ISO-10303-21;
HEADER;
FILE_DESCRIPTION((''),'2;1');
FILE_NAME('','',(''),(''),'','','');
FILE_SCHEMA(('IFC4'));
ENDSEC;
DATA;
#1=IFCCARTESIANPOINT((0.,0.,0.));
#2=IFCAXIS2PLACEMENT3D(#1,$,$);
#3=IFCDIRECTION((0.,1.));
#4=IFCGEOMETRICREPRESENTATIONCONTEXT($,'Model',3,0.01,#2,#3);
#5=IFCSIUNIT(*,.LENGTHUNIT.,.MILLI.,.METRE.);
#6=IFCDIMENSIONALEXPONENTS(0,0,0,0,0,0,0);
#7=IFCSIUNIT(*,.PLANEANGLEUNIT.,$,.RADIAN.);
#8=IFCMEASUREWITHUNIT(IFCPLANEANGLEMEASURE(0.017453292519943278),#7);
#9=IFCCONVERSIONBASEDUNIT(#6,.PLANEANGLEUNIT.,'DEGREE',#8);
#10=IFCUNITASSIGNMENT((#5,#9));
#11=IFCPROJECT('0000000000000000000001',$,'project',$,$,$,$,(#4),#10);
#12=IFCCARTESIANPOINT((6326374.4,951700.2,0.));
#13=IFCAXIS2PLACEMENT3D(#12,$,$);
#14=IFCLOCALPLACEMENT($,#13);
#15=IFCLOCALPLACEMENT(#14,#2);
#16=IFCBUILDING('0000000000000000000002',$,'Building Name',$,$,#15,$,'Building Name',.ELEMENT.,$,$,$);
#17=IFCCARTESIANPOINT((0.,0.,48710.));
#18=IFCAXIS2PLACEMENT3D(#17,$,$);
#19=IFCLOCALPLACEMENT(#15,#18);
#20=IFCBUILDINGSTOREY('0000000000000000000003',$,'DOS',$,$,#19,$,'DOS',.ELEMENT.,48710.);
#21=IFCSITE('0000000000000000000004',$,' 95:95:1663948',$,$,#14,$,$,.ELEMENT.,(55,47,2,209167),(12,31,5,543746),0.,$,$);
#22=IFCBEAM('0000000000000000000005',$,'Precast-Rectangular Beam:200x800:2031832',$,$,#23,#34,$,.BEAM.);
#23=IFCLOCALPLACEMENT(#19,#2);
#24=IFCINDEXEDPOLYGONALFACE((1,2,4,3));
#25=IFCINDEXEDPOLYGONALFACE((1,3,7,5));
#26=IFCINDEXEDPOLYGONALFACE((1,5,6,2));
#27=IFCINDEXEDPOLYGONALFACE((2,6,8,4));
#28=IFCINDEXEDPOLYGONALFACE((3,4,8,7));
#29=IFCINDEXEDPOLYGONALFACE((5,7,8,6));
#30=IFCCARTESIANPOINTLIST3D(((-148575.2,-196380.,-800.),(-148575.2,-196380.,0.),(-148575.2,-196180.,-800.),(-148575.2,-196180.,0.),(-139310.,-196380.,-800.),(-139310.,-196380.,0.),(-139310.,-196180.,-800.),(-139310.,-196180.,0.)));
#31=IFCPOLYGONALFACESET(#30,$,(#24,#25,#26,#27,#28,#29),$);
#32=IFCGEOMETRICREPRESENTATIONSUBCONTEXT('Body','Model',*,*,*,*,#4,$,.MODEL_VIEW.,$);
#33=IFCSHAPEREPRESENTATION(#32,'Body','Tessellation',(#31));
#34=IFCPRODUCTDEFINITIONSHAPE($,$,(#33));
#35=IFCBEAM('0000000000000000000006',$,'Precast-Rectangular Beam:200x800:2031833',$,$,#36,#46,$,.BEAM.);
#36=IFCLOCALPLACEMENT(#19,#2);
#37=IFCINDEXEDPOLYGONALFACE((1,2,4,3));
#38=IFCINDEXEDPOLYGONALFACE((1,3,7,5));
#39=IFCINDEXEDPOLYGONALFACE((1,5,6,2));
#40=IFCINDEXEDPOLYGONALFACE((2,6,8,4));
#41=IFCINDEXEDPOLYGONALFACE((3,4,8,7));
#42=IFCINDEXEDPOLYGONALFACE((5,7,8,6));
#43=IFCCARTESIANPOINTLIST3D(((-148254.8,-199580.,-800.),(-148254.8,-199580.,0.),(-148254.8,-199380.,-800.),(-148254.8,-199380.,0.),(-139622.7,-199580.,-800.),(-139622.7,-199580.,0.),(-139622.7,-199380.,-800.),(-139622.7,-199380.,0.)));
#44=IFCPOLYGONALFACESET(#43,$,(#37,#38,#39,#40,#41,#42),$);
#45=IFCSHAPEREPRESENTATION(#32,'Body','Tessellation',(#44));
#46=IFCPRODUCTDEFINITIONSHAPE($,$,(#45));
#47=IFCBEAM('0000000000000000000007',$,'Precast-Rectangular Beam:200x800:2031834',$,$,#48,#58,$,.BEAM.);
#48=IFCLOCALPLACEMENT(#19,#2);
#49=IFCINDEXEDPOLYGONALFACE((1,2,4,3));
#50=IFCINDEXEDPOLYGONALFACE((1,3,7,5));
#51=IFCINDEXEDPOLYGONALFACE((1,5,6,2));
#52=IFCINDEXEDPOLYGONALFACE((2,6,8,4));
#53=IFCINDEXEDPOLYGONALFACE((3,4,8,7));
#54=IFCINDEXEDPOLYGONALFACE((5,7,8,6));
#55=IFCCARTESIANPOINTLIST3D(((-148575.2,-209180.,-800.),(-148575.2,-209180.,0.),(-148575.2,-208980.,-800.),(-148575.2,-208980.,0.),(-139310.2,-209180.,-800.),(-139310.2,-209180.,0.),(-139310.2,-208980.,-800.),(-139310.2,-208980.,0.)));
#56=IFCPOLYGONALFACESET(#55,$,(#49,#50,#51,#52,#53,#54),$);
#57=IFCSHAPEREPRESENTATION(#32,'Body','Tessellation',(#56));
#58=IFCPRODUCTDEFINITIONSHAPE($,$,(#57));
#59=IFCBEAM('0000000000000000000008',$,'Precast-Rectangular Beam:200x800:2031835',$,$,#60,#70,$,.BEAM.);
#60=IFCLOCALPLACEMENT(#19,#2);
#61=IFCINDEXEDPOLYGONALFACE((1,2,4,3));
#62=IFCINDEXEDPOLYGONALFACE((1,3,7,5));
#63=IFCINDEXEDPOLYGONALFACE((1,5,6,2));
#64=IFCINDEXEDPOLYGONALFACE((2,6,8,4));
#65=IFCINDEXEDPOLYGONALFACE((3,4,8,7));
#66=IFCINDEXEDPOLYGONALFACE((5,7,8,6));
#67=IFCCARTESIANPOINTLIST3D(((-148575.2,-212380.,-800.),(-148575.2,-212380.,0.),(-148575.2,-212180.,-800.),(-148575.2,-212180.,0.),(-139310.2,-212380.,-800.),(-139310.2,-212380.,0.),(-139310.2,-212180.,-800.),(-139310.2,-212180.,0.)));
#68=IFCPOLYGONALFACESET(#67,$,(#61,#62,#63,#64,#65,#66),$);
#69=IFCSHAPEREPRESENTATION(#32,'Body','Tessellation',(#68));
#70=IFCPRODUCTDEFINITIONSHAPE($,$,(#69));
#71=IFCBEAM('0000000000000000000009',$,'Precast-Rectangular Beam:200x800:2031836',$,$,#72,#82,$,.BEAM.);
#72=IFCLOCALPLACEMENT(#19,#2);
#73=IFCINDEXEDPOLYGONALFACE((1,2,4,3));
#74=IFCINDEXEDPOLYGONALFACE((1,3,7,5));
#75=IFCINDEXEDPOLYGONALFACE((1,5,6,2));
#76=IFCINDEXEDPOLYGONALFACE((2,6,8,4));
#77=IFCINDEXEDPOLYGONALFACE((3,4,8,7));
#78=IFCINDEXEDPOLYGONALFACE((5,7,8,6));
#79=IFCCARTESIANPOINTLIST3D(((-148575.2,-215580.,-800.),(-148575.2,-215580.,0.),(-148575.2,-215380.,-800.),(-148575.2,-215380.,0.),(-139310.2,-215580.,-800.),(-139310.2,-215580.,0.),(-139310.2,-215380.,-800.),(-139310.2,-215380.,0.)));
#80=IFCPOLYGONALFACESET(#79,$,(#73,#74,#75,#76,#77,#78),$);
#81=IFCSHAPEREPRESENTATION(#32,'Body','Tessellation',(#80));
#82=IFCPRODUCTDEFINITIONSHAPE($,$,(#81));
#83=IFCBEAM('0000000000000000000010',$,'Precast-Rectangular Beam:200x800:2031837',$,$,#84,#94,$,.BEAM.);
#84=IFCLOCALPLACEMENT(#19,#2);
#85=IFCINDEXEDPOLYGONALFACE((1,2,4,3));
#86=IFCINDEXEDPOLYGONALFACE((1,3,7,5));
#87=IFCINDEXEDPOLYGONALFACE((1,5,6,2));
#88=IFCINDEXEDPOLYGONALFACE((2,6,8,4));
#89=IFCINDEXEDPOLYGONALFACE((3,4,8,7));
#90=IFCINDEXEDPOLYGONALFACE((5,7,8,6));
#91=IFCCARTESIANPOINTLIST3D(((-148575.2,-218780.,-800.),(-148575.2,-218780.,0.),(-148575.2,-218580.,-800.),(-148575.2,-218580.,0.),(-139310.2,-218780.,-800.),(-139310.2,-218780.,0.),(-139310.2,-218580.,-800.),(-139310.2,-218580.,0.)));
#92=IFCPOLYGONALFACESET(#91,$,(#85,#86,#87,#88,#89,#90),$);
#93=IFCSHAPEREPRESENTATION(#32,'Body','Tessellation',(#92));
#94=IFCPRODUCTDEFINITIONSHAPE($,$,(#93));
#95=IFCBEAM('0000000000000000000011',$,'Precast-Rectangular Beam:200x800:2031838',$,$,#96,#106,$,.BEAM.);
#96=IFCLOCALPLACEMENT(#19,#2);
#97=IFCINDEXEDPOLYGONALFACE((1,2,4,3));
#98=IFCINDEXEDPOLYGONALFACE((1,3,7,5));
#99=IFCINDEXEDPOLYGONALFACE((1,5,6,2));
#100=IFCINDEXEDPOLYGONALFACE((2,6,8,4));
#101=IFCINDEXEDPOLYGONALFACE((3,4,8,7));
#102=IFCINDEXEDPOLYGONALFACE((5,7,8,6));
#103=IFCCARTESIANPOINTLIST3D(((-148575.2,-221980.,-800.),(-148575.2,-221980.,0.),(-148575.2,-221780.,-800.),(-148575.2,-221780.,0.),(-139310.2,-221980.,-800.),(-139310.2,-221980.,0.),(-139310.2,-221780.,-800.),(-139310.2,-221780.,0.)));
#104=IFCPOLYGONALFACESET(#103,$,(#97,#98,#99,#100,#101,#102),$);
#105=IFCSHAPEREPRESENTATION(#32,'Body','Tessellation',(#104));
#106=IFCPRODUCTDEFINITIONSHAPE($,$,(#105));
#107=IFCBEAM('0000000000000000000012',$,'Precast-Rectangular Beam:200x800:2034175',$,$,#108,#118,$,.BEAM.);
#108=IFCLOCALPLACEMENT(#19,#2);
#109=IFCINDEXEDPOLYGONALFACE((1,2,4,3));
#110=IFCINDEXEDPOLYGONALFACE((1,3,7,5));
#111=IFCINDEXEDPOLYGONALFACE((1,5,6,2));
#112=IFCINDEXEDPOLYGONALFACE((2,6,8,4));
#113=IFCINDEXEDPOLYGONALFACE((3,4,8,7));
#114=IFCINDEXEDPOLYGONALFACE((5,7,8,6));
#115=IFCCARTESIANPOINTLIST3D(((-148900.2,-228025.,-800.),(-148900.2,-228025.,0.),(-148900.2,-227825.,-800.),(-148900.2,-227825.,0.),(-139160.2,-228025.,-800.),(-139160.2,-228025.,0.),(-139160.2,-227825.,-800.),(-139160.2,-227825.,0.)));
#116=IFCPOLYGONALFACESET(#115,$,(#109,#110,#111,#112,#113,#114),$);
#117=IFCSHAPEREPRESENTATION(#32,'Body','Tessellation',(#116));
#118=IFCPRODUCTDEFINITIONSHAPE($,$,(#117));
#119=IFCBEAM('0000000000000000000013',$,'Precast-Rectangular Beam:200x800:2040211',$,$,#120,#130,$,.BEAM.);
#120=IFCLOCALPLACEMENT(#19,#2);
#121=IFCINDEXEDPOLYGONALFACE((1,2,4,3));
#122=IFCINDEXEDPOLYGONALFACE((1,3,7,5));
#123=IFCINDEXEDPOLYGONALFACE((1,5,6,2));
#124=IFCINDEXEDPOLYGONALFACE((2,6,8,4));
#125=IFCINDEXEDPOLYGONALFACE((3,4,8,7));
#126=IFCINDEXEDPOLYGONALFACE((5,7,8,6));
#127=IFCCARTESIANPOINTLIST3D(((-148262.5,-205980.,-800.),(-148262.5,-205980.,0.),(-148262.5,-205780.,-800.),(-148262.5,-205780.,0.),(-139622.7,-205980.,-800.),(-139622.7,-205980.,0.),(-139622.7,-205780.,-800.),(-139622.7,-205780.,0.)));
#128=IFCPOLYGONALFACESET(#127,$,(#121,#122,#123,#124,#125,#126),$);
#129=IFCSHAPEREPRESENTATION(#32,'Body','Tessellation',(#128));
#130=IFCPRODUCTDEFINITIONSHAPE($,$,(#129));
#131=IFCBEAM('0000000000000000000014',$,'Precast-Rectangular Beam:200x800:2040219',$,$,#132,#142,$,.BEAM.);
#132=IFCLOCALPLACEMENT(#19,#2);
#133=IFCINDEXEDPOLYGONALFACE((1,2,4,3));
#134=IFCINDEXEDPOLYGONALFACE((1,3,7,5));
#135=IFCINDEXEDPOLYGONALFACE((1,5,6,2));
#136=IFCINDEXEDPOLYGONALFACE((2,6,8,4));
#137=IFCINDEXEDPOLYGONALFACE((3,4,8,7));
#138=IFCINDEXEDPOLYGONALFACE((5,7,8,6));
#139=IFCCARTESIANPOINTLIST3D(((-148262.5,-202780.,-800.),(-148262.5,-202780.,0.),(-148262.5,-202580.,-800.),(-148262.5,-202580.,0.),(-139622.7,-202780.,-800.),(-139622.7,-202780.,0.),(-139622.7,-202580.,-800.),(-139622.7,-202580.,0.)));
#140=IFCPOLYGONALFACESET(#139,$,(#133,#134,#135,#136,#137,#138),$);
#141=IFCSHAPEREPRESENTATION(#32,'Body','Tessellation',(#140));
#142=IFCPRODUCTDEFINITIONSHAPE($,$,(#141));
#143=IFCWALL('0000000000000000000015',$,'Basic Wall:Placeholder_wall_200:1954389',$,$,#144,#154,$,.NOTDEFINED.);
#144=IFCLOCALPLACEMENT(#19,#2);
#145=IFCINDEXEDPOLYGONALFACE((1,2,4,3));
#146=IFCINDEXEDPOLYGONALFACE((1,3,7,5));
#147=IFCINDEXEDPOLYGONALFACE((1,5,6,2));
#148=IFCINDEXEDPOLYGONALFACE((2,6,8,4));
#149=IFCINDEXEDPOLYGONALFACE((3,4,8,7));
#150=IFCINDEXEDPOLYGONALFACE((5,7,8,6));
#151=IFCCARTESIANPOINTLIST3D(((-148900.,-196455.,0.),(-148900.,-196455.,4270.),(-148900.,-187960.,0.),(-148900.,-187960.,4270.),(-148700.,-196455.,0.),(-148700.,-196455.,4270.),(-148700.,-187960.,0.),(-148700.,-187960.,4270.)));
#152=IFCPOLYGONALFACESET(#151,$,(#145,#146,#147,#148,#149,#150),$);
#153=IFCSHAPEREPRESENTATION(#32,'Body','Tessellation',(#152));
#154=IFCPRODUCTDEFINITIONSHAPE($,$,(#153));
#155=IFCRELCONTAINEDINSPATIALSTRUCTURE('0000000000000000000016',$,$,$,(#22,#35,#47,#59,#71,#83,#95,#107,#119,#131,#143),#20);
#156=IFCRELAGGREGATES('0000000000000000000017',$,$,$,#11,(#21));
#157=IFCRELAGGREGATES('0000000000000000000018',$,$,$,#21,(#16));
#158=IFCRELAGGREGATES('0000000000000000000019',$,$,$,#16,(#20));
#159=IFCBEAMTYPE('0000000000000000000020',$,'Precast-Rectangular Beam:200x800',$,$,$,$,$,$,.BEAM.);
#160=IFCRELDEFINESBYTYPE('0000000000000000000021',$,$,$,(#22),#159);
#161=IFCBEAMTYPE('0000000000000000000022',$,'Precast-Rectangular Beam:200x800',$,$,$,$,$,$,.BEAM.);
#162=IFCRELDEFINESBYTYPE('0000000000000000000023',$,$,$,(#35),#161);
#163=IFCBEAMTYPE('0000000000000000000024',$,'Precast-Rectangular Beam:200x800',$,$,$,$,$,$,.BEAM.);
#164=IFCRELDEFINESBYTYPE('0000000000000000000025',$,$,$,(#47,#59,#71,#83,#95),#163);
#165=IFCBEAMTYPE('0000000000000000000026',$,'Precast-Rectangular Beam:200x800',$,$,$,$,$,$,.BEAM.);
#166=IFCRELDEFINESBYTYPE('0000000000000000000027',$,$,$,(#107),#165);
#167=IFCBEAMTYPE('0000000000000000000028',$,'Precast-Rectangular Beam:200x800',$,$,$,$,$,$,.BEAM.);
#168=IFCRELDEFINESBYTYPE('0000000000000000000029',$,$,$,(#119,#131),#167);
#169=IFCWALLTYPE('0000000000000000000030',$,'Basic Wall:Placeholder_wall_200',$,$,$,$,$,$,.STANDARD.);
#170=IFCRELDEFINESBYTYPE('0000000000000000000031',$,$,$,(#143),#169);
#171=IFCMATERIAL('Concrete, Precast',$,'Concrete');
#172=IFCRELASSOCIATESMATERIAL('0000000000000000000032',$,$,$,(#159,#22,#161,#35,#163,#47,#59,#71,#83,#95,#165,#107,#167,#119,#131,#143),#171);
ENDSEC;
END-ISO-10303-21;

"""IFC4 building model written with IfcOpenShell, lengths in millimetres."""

from ifc_helpers import new_model, entity, si_unit, converted_unit, direction, frame, origin, place, context, subcontext, project, spatial, indexed_curve, outline, extrude, source, transform, mapped, material, type_object, type_shapes, element, save


model = new_model("IFC4")

# Units and contexts
model_context = context("Model", 3, precision=0.01, world=origin(), true_north=direction((0.0, 1.0)))
body_context = subcontext(model_context, "Body", "Model", "MODEL_VIEW")
ifc_project = project(units=[si_unit("LENGTHUNIT", "METRE", prefix="MILLI"), converted_unit("PLANEANGLEUNIT", "DEGREE", entity("IfcPlaneAngleMeasure", 0.017453292519943278), si_unit("PLANEANGLEUNIT", "RADIAN"), dimensions=[0, 0, 0, 0, 0, 0, 0])], contexts=[model_context])

# Site, building, storey
site_placement = place(None, frame((6326374.4, 951700.2, 0.0)))
site = spatial("IfcSite", under=ifc_project, at=site_placement, Name=" 95:95:1663948", CompositionType="ELEMENT", RefLatitude=(55, 47, 2, 209167), RefLongitude=(12, 31, 5, 543746), RefElevation=0.0)
building_placement = place(site_placement, origin())
building = spatial("IfcBuilding", under=site, at=building_placement, Name="Building Name", LongName="Building Name", CompositionType="ELEMENT")
storey_placement = place(building_placement, frame((0.0, 0.0, 48710.0)))
storey = spatial("IfcBuildingStorey", under=building, at=storey_placement, Name="DOS", LongName="DOS", CompositionType="ELEMENT", Elevation=48710.0)

# Beams
ifc_material_1 = material(Name="Concrete, Precast", Category="Concrete")
beam_type_1 = type_object("IfcBeamType", Name="Precast-Rectangular Beam:200x800", PredefinedType="BEAM", material=ifc_material_1)
shared_shape_1 = source(origin(), body_context, "Body", "SweptSolid", [
    extrude(outline(indexed_curve([(-4632.6, -100.0), (4632.6, -100.0), (4632.6, 100.0), (-4632.6, 100.0), (-4632.6, -100.0)], self_intersect=False)), frame((-2.6, 0.0, -400.0), z_axis=(0.0, 0.0, 1.0), x_axis=(-1.0, 0.0, 0.0)), (0.0, 0.0, 1.0), 800.0),
])
type_shapes(beam_type_1, [shared_shape_1])
for number, where, name in (
    (1, (-143940.0, -196280.0, -400.0), "Precast-Rectangular Beam:200x800:2031832"),
):
    element("IfcBeam", number, at=place(storey_placement, frame(where)), inside=storey, type_object=beam_type_1, material=ifc_material_1, Name=name, PredefinedType="BEAM", context=body_context, shape_type="MappedRepresentation", body=[
        mapped(shared_shape_1, transform((0.0, 0.0, 0.0), scale=1.0)),
    ])
beam_type_2 = type_object("IfcBeamType", Name="Precast-Rectangular Beam:200x800", PredefinedType="BEAM", material=ifc_material_1)
shared_shape_2 = source(origin(), body_context, "Body", "SweptSolid", [
    extrude(outline(indexed_curve([(-4316.0, -100.0), (4316.0, -100.0), (4316.0, 100.0), (-4316.0, 100.0), (-4316.0, -100.0)], self_intersect=False)), frame((1.2, 0.0, -400.0), z_axis=(0.0, 0.0, 1.0), x_axis=(-1.0, 0.0, 0.0)), (0.0, 0.0, 1.0), 800.0),
])
type_shapes(beam_type_2, [shared_shape_2])
beam_1_placement = place(storey_placement, frame((-143940.0, -199480.0, -400.0)))
element("IfcBeam", 2, at=beam_1_placement, inside=storey, type_object=beam_type_2, material=ifc_material_1, Name="Precast-Rectangular Beam:200x800:2031833", PredefinedType="BEAM", context=body_context, shape_type="MappedRepresentation", body=[
    mapped(shared_shape_2, transform((0.0, 0.0, 0.0), scale=1.0)),
])
beam_type_3 = type_object("IfcBeamType", Name="Precast-Rectangular Beam:200x800", PredefinedType="BEAM", material=ifc_material_1)
shared_shape_3 = source(origin(), body_context, "Body", "SweptSolid", [
    extrude(outline(indexed_curve([(-4632.5, -100.0), (4632.5, -100.0), (4632.5, 100.0), (-4632.5, 100.0), (-4632.5, -100.0)], self_intersect=False)), frame((-32.7, 0.0, -400.0), z_axis=(0.0, 0.0, 1.0), x_axis=(-1.0, 0.0, 0.0)), (0.0, 0.0, 1.0), 800.0),
])
type_shapes(beam_type_3, [shared_shape_3])
for number, where, name in (
    (3, (-143910.0, -209080.0, -400.0), "Precast-Rectangular Beam:200x800:2031834"),
    (4, (-143910.0, -212280.0, -400.0), "Precast-Rectangular Beam:200x800:2031835"),
    (5, (-143910.0, -215480.0, -400.0), "Precast-Rectangular Beam:200x800:2031836"),
    (6, (-143910.0, -218680.0, -400.0), "Precast-Rectangular Beam:200x800:2031837"),
    (7, (-143910.0, -221880.0, -400.0), "Precast-Rectangular Beam:200x800:2031838"),
):
    element("IfcBeam", number, at=place(storey_placement, frame(where)), inside=storey, type_object=beam_type_3, material=ifc_material_1, Name=name, PredefinedType="BEAM", context=body_context, shape_type="MappedRepresentation", body=[
        mapped(shared_shape_3, transform((0.0, 0.0, 0.0), scale=1.0)),
    ])
beam_type_4 = type_object("IfcBeamType", Name="Precast-Rectangular Beam:200x800", PredefinedType="BEAM", material=ifc_material_1)
shared_shape_4 = source(origin(), body_context, "Body", "SweptSolid", [
    extrude(outline(indexed_curve([(-4870.0, -100.0), (4870.0, -100.0), (4870.0, 100.0), (-4870.0, 100.0), (-4870.0, -100.0)], self_intersect=False)), frame((-50.1, 0.0, -400.0), z_axis=(0.0, 0.0, 1.0), x_axis=(-1.0, 0.0, 0.0)), (0.0, 0.0, 1.0), 800.0),
])
type_shapes(beam_type_4, [shared_shape_4])
beam_2_placement = place(storey_placement, frame((-143980.1, -227925.0, -400.0)))
element("IfcBeam", 8, at=beam_2_placement, inside=storey, type_object=beam_type_4, material=ifc_material_1, Name="Precast-Rectangular Beam:200x800:2034175", PredefinedType="BEAM", context=body_context, shape_type="MappedRepresentation", body=[
    mapped(shared_shape_4, transform((0.0, 0.0, 0.0), scale=1.0)),
])
beam_type_5 = type_object("IfcBeamType", Name="Precast-Rectangular Beam:200x800", PredefinedType="BEAM", material=ifc_material_1)
shared_shape_5 = source(origin(), body_context, "Body", "SweptSolid", [
    extrude(outline(indexed_curve([(-4319.9, -100.0), (4319.9, -100.0), (4319.9, 100.0), (-4319.9, 100.0), (-4319.9, -100.0)], self_intersect=False)), frame((-32.6, 0.0, -400.0), z_axis=(0.0, 0.0, 1.0), x_axis=(-1.0, 0.0, 0.0)), (0.0, 0.0, 1.0), 800.0),
])
type_shapes(beam_type_5, [shared_shape_5])
for number, where, name in (
    (9, (-143910.0, -205880.0, -400.0), "Precast-Rectangular Beam:200x800:2040211"),
    (10, (-143910.0, -202680.0, -400.0), "Precast-Rectangular Beam:200x800:2040219"),
):
    element("IfcBeam", number, at=place(storey_placement, frame(where)), inside=storey, type_object=beam_type_5, material=ifc_material_1, Name=name, PredefinedType="BEAM", context=body_context, shape_type="MappedRepresentation", body=[
        mapped(shared_shape_5, transform((0.0, 0.0, 0.0), scale=1.0)),
    ])

# Wall
wall_type = type_object("IfcWallType", Name="Basic Wall:Placeholder_wall_200", PredefinedType="STANDARD")
wall_placement = place(storey_placement, frame((-148800.0, -196455.0, 0.0), z_axis=(0.0, 0.0, 1.0), x_axis=(0.0, 1.0, 0.0)))
element("IfcWall", 11, at=wall_placement, inside=storey, type_object=wall_type, material=ifc_material_1, Name="Basic Wall:Placeholder_wall_200:1954389", PredefinedType="NOTDEFINED", context=body_context, shape_type="SweptSolid", body=[
    extrude(outline(indexed_curve([(8495.0, 100.0), (0.0, 100.0), (0.0, -100.0), (8495.0, -100.0), (8495.0, 100.0)], self_intersect=False)), origin(), (0.0, 0.0, 1.0), 4270.0),
])

save(model, "model.ifc")
